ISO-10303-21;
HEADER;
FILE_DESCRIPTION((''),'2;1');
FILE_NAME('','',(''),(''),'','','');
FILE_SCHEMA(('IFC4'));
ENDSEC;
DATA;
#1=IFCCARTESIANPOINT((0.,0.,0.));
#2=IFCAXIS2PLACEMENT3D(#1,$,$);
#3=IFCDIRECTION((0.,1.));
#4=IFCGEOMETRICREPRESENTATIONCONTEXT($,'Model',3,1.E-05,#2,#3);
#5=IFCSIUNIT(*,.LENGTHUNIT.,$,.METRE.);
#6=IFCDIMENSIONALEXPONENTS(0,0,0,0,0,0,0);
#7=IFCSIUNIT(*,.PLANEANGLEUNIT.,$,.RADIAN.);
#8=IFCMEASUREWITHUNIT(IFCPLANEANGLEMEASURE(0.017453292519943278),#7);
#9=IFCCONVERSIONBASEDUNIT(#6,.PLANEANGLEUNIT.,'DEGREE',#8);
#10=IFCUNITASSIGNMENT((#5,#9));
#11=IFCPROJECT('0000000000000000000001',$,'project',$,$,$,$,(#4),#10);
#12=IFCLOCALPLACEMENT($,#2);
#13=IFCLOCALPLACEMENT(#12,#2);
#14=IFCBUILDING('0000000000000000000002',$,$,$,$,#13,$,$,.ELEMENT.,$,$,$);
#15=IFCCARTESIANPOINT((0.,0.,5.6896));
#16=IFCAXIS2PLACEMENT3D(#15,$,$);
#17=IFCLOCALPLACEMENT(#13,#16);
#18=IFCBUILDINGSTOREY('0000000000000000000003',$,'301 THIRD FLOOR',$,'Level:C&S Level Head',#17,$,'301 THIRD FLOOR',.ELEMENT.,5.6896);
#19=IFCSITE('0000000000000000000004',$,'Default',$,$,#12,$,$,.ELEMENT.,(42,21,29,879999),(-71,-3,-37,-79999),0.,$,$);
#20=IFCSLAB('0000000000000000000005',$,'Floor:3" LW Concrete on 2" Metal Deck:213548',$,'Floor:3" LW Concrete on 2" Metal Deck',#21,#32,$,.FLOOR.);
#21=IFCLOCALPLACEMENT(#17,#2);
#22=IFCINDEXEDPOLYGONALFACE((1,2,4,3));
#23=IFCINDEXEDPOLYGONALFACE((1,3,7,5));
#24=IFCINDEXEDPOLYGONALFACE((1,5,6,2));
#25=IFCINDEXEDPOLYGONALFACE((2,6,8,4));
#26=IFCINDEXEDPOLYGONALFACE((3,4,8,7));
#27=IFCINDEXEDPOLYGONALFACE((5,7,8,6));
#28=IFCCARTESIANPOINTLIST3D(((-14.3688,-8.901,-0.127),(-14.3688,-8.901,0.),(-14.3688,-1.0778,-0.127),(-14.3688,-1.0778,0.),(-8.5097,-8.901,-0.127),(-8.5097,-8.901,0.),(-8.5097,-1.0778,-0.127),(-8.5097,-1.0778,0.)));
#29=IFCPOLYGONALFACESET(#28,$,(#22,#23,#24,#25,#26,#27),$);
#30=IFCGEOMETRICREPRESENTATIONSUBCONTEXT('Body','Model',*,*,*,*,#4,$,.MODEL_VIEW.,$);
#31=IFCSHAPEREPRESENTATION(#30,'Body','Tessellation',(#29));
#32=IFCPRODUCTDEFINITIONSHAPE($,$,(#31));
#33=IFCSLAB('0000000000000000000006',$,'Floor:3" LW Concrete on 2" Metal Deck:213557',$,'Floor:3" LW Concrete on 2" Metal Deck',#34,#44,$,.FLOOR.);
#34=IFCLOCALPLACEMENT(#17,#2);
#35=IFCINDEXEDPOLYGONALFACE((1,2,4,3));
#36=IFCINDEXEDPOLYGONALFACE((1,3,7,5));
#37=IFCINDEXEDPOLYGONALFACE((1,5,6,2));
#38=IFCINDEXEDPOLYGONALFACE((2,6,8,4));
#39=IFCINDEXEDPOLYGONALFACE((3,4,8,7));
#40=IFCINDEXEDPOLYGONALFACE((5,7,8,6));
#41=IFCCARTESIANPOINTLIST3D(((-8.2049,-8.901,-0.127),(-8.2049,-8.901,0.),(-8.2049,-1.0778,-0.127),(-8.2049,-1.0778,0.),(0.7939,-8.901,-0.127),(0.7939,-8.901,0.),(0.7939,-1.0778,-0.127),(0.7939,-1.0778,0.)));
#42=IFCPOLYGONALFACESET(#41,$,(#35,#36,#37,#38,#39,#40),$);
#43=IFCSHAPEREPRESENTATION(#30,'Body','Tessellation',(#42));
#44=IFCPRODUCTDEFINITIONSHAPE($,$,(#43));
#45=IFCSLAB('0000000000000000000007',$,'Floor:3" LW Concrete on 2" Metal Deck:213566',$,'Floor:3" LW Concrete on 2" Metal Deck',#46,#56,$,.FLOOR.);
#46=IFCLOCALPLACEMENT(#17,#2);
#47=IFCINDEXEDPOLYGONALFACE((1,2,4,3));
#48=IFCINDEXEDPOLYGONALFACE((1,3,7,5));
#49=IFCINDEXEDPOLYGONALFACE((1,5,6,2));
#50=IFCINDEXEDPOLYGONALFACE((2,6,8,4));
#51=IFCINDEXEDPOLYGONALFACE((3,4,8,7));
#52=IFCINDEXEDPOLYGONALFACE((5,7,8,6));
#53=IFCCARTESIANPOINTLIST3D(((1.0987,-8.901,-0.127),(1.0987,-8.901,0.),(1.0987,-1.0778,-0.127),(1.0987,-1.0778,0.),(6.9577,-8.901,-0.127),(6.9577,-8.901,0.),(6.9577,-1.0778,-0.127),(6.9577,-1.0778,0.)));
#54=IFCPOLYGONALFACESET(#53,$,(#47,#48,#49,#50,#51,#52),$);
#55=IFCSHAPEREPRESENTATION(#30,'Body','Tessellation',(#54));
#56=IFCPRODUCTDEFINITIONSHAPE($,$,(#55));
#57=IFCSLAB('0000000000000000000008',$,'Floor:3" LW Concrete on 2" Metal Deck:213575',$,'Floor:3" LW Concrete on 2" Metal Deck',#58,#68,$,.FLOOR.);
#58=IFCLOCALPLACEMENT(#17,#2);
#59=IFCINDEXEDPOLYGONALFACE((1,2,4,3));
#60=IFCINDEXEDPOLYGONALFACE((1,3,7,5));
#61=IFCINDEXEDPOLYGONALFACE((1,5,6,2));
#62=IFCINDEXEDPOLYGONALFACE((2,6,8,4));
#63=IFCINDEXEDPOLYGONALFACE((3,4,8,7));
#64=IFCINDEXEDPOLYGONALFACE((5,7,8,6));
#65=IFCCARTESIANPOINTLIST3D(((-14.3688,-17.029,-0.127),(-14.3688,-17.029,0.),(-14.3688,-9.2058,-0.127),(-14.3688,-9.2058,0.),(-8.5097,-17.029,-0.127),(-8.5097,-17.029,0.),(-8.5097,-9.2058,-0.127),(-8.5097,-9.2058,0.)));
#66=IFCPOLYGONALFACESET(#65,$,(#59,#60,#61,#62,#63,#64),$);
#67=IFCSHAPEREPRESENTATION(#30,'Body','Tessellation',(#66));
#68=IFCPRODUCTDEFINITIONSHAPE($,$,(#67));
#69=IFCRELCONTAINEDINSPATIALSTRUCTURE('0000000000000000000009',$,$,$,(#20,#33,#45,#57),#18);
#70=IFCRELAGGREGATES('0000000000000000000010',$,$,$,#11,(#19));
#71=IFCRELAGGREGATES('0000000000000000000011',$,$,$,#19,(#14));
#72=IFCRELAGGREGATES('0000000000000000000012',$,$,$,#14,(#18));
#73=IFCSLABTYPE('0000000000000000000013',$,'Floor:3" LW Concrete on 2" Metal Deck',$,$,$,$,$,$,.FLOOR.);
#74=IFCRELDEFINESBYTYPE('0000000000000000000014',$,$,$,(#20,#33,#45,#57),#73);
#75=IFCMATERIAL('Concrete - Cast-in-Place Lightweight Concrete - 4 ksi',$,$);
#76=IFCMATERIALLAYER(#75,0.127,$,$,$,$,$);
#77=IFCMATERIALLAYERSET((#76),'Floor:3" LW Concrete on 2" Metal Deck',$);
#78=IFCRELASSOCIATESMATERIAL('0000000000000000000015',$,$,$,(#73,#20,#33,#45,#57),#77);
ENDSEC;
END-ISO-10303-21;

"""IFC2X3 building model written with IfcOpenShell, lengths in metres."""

from ifc_helpers import new_model, entity, si_unit, converted_unit, direction, frame, frame_2d, origin, origin_2d_with_axis, place, context, subcontext, project, spatial, rectangle, extrude, material, layer, layer_set, layer_usage, type_object, element, save


model = new_model("IFC2X3")

# Units and contexts
model_context = context("Model", 3, precision=1e-05, world=origin(), true_north=direction((0.0, 1.0)))
body_context = subcontext(model_context, "Body", "Model", "MODEL_VIEW")
ifc_project = project(units=[si_unit("LENGTHUNIT", "METRE"), converted_unit("PLANEANGLEUNIT", "DEGREE", entity("IfcPlaneAngleMeasure", 0.017453292519943278), si_unit("PLANEANGLEUNIT", "RADIAN"), dimensions=[0, 0, 0, 0, 0, 0, 0])], contexts=[model_context])

# Site, building, storey
site_placement = place(None, origin())
site = spatial("IfcSite", under=ifc_project, at=site_placement, Name="Default", CompositionType="ELEMENT", RefLatitude=(42, 21, 29, 879999), RefLongitude=(-71, -3, -37, -79999), RefElevation=0.0)
building_placement = place(site_placement, origin())
building = spatial("IfcBuilding", under=site, at=building_placement, CompositionType="ELEMENT")
storey_placement = place(building_placement, frame((0.0, 0.0, 5.6896)))
storey = spatial("IfcBuildingStorey", under=building, at=storey_placement, Name="301 THIRD FLOOR", ObjectType="Level:C&S Level Head", LongName="301 THIRD FLOOR", CompositionType="ELEMENT", Elevation=5.6896)

# Slabs
ifc_material_1 = material(Name="Concrete - Cast-in-Place Lightweight Concrete - 4 ksi")
ifc_layer = layer(ifc_material_1, 0.127)
ifc_layer_set = layer_set([ifc_layer], Name="Floor:3\" LW Concrete on 2\" Metal Deck")
slab_type = type_object("IfcSlabType", Name="Floor:3\" LW Concrete on 2\" Metal Deck", PredefinedType="FLOOR", material=ifc_layer_set)
ifc_layer_usage_1 = layer_usage(ifc_layer_set, "AXIS3", "POSITIVE", 0.0)
slab_1_placement = place(storey_placement, origin())
element("IfcSlab", 1, at=slab_1_placement, inside=storey, type_object=slab_type, material=ifc_layer_usage_1, Name="Floor:3\" LW Concrete on 2\" Metal Deck:213548", ObjectType="Floor:3\" LW Concrete on 2\" Metal Deck", PredefinedType="FLOOR", context=body_context, shape_type="SweptSolid", body=[
    extrude(rectangle(XDim=7.8232, YDim=5.859, at=origin_2d_with_axis()), frame((-11.4393, -4.9894, 0.0), z_axis=(0.0, 0.0, -1.0), x_axis=(0.0, 1.0, 0.0)), (0.0, 0.0, 1.0), 0.127),
])
ifc_layer_usage_2 = layer_usage(ifc_layer_set, "AXIS3", "POSITIVE", 0.0)
slab_2_placement = place(storey_placement, origin())
element("IfcSlab", 2, at=slab_2_placement, inside=storey, type_object=slab_type, material=ifc_layer_usage_2, Name="Floor:3\" LW Concrete on 2\" Metal Deck:213557", ObjectType="Floor:3\" LW Concrete on 2\" Metal Deck", PredefinedType="FLOOR", context=body_context, shape_type="SweptSolid", body=[
    extrude(rectangle(XDim=7.8232, YDim=8.9988, at=frame_2d((0.0, 0.0), x_axis=(1.0, 0.0))), frame((-3.7055, -4.9894, 0.0), z_axis=(0.0, 0.0, -1.0), x_axis=(0.0, 1.0, 0.0)), (0.0, 0.0, 1.0), 0.127),
])
ifc_layer_usage_3 = layer_usage(ifc_layer_set, "AXIS3", "POSITIVE", 0.0)
slab_3_placement = place(storey_placement, origin())
element("IfcSlab", 3, at=slab_3_placement, inside=storey, type_object=slab_type, material=ifc_layer_usage_3, Name="Floor:3\" LW Concrete on 2\" Metal Deck:213566", ObjectType="Floor:3\" LW Concrete on 2\" Metal Deck", PredefinedType="FLOOR", context=body_context, shape_type="SweptSolid", body=[
    extrude(rectangle(XDim=7.8232, YDim=5.859, at=origin_2d_with_axis()), frame((4.0282, -4.9894, 0.0), z_axis=(0.0, 0.0, -1.0), x_axis=(0.0, 1.0, 0.0)), (0.0, 0.0, 1.0), 0.127),
])
ifc_layer_usage_4 = layer_usage(ifc_layer_set, "AXIS3", "POSITIVE", 0.0)
slab_4_placement = place(storey_placement, origin())
element("IfcSlab", 4, at=slab_4_placement, inside=storey, type_object=slab_type, material=ifc_layer_usage_4, Name="Floor:3\" LW Concrete on 2\" Metal Deck:213575", ObjectType="Floor:3\" LW Concrete on 2\" Metal Deck", PredefinedType="FLOOR", context=body_context, shape_type="SweptSolid", body=[
    extrude(rectangle(XDim=7.8232, YDim=5.859, at=frame_2d((0.0, 0.0), x_axis=(1.0, 0.0))), frame((-11.4393, -13.1174, 0.0), z_axis=(0.0, 0.0, -1.0), x_axis=(0.0, 1.0, 0.0)), (0.0, 0.0, 1.0), 0.127),
])

save(model, "model.ifc")
